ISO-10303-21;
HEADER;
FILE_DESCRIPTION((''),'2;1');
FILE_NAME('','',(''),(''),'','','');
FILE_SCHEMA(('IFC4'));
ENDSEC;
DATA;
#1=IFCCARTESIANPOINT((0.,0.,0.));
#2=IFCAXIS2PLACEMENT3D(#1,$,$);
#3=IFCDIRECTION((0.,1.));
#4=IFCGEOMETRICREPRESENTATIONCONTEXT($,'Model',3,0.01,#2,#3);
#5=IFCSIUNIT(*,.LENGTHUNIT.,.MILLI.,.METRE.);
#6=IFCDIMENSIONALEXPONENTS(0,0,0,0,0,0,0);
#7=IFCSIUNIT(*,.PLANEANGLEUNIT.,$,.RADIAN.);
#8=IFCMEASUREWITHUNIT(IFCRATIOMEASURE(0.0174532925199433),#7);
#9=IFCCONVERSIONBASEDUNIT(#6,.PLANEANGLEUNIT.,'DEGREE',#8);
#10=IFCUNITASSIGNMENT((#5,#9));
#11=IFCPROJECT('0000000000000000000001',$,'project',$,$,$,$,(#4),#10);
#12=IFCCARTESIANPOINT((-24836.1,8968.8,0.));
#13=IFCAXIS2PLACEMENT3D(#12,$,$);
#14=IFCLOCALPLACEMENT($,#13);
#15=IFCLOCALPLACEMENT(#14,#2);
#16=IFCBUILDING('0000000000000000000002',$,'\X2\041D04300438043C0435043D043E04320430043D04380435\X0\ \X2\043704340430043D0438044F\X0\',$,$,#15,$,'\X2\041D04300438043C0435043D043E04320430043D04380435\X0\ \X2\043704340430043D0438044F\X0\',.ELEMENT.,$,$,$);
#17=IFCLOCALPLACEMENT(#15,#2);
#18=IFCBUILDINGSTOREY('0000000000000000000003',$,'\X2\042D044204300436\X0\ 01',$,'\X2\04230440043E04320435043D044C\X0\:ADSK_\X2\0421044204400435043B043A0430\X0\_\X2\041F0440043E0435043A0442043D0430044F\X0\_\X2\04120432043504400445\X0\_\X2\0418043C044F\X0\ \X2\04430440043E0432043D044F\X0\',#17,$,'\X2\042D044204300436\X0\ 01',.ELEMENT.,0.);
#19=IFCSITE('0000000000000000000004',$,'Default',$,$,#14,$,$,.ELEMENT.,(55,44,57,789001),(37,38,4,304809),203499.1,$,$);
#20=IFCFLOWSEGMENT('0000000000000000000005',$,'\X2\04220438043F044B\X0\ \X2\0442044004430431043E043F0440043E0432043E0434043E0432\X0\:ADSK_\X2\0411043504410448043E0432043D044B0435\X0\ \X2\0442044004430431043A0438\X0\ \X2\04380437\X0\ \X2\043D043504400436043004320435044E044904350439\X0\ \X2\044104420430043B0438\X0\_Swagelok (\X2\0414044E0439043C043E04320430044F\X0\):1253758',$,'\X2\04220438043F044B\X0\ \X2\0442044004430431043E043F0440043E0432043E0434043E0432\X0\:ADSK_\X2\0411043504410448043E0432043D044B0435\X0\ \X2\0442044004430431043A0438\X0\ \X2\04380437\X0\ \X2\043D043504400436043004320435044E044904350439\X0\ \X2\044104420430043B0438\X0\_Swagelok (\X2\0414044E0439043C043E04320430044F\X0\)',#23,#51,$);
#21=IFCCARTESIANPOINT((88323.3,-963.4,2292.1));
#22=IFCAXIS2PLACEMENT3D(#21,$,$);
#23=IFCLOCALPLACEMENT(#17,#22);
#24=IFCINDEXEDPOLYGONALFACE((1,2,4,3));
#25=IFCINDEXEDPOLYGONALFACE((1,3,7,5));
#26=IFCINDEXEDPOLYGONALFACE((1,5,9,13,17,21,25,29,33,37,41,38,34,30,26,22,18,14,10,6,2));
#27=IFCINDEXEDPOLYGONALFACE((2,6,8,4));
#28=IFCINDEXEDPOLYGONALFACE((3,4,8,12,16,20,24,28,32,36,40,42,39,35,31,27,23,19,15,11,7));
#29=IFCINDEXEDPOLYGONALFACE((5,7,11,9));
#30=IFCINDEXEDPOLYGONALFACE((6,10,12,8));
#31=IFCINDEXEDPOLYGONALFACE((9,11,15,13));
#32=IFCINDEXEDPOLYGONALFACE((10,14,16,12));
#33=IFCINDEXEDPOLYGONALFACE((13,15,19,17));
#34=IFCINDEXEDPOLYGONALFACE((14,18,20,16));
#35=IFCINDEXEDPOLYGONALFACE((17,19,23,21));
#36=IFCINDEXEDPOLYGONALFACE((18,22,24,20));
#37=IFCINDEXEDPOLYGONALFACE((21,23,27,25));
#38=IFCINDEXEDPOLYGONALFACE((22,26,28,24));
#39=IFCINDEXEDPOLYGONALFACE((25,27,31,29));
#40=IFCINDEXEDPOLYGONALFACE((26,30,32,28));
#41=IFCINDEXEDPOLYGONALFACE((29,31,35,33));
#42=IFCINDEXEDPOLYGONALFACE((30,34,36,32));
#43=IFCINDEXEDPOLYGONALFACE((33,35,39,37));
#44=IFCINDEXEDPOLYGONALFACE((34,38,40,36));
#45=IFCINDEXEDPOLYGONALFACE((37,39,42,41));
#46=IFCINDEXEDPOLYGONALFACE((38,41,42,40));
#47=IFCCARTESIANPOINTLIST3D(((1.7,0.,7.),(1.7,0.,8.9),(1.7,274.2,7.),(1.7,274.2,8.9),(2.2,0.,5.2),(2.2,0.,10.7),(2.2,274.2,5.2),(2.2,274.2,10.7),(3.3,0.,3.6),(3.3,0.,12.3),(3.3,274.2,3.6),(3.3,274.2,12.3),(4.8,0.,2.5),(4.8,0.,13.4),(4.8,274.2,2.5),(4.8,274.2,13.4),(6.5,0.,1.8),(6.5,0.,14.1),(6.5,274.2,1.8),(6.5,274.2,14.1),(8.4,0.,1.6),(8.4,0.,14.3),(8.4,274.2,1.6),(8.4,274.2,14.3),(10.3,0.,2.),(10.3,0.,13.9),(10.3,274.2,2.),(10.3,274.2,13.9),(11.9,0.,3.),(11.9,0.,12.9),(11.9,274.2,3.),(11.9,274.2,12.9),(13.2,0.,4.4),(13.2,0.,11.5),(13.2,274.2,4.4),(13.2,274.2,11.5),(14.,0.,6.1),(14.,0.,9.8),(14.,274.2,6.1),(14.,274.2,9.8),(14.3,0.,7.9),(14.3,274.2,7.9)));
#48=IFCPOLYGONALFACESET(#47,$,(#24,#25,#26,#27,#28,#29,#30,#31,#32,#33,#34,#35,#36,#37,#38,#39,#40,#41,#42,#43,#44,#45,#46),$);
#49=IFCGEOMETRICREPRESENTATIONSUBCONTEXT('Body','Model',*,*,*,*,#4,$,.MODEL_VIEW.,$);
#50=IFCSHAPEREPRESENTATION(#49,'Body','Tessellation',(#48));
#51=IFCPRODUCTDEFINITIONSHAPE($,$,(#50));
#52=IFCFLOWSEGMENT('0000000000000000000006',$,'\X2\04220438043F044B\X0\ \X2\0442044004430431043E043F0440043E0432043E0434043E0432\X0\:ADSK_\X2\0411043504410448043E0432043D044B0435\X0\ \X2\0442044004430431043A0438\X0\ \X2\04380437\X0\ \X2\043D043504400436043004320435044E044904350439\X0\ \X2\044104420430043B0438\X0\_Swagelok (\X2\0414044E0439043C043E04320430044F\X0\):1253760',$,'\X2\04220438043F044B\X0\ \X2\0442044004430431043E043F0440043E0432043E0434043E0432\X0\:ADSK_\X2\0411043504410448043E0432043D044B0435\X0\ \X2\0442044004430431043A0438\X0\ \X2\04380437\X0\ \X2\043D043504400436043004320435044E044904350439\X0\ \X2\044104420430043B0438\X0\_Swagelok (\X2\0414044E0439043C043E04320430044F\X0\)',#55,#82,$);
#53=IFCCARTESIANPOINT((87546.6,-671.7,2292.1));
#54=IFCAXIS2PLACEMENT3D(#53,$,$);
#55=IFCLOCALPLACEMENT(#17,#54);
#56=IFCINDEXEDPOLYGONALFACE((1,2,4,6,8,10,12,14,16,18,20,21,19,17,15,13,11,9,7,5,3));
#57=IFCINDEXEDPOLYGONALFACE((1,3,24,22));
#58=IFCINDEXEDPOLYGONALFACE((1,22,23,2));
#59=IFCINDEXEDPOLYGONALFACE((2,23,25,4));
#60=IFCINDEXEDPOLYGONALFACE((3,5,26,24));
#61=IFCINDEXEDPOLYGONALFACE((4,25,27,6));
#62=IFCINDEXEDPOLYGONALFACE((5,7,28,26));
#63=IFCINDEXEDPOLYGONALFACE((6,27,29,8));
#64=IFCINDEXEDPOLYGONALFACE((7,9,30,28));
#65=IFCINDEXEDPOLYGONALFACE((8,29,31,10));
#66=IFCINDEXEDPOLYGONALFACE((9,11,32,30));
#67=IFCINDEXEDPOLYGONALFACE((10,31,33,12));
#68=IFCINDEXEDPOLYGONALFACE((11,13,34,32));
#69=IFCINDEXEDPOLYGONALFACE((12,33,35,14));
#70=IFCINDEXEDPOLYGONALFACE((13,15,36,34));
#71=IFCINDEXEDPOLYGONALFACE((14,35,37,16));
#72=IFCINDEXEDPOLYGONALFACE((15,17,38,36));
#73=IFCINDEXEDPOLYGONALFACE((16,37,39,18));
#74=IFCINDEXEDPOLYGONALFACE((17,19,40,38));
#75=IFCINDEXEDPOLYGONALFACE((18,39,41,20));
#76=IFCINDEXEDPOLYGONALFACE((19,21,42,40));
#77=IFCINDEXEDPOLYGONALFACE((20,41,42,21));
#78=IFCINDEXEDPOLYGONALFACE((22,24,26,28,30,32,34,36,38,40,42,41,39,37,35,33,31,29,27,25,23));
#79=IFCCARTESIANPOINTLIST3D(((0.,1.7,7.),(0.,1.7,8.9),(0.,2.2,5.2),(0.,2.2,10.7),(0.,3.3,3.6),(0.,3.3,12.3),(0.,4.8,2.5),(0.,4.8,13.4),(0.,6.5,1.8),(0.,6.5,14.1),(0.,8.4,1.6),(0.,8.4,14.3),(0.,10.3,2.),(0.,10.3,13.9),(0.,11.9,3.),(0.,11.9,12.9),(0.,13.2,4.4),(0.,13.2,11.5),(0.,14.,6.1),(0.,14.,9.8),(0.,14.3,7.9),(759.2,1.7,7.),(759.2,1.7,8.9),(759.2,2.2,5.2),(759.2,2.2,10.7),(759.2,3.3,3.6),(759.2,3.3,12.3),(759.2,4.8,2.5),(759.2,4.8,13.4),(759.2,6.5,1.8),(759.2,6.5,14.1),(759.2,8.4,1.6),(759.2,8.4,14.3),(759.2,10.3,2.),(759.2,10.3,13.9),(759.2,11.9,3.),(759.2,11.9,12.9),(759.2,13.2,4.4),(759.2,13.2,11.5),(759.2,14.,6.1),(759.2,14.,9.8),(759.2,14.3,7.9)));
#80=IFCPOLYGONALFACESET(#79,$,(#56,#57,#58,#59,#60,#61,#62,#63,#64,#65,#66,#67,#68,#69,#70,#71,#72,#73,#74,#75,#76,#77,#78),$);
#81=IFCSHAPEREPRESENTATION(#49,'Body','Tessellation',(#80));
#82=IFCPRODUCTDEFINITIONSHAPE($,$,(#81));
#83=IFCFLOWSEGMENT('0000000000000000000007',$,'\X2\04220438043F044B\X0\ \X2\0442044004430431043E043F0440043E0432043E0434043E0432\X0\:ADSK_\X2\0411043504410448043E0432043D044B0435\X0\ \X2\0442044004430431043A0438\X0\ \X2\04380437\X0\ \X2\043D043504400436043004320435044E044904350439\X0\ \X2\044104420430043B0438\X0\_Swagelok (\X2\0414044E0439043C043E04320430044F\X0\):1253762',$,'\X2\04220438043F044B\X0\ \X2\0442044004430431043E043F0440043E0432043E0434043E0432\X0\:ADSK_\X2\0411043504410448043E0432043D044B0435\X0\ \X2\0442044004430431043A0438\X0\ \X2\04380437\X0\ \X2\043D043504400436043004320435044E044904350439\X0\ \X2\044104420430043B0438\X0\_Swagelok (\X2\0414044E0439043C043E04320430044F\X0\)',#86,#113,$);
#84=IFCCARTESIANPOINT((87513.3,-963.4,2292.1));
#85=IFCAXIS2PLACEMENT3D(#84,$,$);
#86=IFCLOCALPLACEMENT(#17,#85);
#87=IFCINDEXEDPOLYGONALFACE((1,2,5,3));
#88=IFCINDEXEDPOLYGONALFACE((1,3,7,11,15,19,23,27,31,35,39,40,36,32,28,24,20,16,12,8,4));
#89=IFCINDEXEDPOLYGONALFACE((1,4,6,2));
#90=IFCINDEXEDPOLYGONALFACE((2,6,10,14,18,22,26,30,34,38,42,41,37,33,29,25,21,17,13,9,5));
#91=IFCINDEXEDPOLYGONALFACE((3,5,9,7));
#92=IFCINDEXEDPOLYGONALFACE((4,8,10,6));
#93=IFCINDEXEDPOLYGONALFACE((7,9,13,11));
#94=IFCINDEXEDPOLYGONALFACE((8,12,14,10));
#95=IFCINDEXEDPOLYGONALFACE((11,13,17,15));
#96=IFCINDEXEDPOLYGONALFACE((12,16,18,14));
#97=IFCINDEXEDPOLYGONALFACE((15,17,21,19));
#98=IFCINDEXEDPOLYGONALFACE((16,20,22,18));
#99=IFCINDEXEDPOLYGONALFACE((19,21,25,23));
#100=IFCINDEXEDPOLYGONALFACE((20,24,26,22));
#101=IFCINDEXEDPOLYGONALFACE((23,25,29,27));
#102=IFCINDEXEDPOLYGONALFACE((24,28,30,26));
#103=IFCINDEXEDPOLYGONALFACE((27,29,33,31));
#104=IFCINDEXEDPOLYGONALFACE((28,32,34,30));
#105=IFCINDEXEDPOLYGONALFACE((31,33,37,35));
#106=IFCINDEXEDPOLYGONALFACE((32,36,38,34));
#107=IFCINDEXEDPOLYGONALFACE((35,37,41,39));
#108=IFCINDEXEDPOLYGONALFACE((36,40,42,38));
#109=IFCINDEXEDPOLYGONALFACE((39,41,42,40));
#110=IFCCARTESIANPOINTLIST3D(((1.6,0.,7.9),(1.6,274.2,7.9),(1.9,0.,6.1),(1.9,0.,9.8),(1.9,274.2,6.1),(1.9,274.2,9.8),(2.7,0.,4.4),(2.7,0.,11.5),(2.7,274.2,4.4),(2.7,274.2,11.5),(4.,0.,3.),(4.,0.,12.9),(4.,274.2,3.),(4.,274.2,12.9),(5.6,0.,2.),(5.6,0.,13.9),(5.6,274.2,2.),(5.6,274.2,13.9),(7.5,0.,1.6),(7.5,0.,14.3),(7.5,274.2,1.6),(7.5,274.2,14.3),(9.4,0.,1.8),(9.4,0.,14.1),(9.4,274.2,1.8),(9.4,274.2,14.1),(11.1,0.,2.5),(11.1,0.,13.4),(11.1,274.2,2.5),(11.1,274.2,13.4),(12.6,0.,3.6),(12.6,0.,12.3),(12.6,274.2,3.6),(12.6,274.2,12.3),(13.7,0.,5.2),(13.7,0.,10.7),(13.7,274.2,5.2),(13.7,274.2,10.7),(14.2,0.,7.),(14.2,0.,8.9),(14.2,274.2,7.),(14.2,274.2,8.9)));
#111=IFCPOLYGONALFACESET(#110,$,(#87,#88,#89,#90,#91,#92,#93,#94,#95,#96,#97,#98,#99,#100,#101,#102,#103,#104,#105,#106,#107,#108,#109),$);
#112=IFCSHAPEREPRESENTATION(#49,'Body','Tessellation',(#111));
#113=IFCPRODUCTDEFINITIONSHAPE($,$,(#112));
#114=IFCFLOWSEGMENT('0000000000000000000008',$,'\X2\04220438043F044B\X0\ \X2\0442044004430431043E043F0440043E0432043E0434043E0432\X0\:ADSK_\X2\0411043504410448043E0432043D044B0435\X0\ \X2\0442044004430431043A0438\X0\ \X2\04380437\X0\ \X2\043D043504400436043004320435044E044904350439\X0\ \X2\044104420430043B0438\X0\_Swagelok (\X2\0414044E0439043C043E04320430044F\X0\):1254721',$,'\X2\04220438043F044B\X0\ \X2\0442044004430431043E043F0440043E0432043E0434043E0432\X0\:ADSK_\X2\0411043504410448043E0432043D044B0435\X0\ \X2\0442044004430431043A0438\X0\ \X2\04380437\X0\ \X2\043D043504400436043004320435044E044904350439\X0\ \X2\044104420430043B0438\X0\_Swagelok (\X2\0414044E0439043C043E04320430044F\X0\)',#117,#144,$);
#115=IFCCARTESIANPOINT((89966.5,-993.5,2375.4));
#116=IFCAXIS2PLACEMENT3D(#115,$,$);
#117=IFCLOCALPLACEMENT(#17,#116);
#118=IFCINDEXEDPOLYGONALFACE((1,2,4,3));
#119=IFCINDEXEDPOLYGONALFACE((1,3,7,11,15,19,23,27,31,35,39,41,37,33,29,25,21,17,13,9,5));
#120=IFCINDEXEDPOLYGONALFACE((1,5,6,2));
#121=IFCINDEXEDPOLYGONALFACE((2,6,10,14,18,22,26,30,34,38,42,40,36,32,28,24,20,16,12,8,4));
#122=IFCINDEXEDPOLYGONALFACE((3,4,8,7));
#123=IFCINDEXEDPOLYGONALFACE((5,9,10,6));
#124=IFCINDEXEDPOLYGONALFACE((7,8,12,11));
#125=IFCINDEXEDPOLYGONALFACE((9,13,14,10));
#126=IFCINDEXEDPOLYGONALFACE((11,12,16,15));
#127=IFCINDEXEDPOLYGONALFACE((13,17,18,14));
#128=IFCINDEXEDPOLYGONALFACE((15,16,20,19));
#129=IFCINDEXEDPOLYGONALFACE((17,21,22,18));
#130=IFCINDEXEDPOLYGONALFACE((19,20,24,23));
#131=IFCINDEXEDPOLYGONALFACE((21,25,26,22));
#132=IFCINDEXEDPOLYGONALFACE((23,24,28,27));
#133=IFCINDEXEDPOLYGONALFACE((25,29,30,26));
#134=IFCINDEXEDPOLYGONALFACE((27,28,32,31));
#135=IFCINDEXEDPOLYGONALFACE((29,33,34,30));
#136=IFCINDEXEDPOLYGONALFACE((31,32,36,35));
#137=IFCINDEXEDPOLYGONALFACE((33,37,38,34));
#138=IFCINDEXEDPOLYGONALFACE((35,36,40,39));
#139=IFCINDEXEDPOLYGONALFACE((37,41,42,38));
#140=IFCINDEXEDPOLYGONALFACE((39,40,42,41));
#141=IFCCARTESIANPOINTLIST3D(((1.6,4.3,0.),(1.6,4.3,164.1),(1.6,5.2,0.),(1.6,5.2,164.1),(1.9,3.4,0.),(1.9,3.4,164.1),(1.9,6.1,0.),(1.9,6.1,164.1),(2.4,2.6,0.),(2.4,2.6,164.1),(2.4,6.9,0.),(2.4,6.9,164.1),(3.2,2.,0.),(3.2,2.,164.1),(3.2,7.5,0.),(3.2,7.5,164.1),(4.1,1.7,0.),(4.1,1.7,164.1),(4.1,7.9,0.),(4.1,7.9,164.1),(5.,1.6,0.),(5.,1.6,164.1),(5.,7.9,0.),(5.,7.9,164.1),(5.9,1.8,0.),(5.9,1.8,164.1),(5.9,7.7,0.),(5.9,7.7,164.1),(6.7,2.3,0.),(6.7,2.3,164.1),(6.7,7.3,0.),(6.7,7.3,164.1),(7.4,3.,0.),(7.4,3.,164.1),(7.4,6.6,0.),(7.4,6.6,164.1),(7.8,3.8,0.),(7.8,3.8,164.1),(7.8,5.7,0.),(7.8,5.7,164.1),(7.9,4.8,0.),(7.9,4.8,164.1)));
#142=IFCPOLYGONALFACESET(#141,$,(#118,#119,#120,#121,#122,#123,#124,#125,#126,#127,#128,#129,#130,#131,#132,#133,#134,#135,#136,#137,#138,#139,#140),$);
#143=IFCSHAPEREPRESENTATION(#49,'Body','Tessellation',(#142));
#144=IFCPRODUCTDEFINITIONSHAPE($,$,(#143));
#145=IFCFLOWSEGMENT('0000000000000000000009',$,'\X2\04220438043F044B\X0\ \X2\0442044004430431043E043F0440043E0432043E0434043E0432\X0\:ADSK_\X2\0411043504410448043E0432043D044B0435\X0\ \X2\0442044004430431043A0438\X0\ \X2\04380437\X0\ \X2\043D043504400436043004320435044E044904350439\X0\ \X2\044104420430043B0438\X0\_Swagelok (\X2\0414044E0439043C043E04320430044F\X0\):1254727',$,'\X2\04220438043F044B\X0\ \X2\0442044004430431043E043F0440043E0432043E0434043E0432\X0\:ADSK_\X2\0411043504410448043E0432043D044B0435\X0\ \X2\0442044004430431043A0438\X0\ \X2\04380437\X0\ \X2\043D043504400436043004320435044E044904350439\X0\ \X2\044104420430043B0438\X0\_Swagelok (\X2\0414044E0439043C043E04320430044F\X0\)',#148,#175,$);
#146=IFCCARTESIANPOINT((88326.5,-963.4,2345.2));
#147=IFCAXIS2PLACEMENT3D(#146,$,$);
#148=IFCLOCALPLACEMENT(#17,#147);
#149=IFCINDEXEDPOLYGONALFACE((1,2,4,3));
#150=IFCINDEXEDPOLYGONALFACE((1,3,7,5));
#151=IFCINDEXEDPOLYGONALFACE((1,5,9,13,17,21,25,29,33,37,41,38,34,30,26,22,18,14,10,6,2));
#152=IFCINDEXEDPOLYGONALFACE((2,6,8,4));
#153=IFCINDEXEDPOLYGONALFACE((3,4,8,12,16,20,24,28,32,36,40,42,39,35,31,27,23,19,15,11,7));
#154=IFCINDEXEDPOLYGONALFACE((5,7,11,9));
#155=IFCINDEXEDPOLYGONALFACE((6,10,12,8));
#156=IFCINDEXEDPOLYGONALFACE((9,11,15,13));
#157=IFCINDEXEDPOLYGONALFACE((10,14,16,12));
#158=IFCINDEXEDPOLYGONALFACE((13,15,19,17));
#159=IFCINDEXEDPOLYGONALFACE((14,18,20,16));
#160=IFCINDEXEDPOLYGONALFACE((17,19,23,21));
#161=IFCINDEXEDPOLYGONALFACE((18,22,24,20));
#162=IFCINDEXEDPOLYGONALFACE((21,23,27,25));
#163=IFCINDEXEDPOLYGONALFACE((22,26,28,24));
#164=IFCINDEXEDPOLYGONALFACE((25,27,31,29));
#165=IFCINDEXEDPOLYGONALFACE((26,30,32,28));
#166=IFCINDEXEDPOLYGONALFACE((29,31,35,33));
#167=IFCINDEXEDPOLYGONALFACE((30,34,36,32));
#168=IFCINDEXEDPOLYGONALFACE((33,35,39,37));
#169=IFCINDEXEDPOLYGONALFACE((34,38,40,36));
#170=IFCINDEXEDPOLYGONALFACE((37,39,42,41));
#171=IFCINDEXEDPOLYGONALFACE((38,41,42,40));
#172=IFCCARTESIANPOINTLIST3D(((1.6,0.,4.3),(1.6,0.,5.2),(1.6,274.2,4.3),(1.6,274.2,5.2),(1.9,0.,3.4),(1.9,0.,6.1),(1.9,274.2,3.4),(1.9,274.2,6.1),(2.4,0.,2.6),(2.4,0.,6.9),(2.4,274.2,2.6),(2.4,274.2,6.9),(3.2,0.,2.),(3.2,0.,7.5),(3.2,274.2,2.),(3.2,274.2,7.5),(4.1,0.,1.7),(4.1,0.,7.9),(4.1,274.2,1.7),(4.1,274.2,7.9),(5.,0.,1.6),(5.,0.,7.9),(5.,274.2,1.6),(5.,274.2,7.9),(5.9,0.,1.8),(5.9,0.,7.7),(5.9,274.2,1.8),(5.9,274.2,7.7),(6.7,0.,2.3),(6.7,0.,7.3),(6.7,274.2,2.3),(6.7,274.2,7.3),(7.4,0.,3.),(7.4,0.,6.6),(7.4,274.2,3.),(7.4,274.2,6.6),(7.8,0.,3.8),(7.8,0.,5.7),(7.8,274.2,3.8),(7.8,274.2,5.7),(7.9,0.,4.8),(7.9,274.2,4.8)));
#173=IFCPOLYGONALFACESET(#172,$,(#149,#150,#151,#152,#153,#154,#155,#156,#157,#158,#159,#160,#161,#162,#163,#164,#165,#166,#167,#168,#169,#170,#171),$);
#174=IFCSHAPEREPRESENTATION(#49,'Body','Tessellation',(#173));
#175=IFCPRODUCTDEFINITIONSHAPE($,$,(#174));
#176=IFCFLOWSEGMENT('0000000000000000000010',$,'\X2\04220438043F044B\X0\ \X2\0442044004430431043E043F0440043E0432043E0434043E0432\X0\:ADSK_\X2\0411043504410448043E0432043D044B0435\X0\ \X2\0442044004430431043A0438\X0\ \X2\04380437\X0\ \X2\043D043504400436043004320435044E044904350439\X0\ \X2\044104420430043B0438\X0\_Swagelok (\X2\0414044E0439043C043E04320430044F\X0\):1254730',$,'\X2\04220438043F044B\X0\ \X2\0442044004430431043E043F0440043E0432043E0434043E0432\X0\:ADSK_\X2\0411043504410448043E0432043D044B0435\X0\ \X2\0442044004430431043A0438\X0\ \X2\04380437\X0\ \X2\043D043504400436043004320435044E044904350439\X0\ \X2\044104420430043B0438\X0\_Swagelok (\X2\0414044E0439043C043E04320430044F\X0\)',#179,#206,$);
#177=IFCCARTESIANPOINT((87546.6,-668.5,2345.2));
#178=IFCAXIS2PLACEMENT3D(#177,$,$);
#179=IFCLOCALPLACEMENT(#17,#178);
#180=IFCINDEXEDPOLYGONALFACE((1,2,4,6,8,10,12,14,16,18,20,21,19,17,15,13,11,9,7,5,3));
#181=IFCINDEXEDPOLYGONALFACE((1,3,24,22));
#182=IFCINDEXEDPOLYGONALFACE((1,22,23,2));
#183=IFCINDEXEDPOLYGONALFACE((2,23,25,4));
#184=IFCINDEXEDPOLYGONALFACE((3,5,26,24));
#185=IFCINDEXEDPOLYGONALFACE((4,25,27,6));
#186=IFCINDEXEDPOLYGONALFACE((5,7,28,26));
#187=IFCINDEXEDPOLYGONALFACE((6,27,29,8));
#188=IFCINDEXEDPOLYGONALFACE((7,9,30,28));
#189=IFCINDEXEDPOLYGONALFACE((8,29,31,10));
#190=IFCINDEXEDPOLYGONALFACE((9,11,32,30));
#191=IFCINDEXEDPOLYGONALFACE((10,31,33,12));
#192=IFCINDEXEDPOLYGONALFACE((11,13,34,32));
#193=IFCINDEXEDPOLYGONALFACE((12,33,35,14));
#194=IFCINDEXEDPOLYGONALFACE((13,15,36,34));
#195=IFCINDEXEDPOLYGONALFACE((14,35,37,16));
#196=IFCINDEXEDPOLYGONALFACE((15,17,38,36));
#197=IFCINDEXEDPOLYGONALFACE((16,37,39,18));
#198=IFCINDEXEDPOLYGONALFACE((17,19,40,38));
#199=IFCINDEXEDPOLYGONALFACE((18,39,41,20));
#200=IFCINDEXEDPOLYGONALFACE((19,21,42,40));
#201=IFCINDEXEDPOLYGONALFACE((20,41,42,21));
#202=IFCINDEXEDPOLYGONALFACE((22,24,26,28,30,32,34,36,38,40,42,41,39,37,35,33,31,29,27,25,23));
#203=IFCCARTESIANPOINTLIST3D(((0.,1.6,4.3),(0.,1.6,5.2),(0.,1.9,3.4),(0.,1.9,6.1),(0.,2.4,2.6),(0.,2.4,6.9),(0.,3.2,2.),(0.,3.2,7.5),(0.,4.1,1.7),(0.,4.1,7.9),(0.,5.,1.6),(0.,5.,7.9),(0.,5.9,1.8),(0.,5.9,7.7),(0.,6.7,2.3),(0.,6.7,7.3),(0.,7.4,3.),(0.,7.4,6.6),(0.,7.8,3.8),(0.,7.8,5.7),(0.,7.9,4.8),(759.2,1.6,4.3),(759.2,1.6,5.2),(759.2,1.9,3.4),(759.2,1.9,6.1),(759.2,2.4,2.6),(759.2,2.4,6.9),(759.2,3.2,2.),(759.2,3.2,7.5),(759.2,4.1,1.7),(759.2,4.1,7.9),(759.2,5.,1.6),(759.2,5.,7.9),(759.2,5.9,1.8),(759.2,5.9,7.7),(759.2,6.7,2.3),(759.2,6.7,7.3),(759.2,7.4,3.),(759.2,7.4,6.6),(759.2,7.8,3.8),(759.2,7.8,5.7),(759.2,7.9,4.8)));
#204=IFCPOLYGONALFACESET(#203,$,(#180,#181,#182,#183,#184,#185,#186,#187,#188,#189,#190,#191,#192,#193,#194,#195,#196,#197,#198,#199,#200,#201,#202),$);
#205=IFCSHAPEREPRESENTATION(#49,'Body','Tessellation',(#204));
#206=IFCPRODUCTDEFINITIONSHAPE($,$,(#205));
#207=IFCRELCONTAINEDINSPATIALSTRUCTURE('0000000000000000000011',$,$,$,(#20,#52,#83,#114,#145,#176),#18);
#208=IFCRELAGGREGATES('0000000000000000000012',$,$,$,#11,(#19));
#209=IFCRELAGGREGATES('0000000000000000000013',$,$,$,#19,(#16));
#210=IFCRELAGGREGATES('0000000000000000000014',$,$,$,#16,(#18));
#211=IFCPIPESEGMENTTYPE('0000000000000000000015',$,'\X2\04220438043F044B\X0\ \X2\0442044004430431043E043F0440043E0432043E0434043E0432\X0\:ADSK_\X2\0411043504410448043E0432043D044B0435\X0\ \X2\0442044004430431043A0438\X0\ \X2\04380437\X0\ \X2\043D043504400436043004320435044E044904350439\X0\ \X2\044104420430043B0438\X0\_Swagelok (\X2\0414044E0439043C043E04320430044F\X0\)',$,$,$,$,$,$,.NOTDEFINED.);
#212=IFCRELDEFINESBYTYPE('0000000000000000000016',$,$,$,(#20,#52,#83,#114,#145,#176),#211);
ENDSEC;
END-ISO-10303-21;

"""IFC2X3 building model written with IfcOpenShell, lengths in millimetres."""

from ifc_helpers import new_model, entity, si_unit, converted_unit, direction, frame, origin, origin_2d_with_axis, place, context, subcontext, project, spatial, circle, extrude, type_object, element, save


model = new_model("IFC2X3")

# Units and contexts
model_context = context("Model", 3, precision=0.01, world=origin(), true_north=direction((0.0, 1.0)))
body_context = subcontext(model_context, "Body", "Model", "MODEL_VIEW")
ifc_project = project(units=[si_unit("LENGTHUNIT", "METRE", prefix="MILLI"), converted_unit("PLANEANGLEUNIT", "DEGREE", entity("IfcRatioMeasure", 0.0174532925199433), si_unit("PLANEANGLEUNIT", "RADIAN"), dimensions=[0, 0, 0, 0, 0, 0, 0])], contexts=[model_context])

# Site, building, storey
site_placement = place(None, frame((-24836.1, 8968.8, 0.0)))
site = spatial("IfcSite", under=ifc_project, at=site_placement, Name="Default", CompositionType="ELEMENT", RefLatitude=(55, 44, 57, 789001), RefLongitude=(37, 38, 4, 304809), RefElevation=203499.1)
building_placement = place(site_placement, origin())
building = spatial("IfcBuilding", under=site, at=building_placement, Name="Наименование здания", LongName="Наименование здания", CompositionType="ELEMENT")
storey_placement = place(building_placement, origin())
storey = spatial("IfcBuildingStorey", under=building, at=storey_placement, Name="Этаж 01", ObjectType="Уровень:ADSK_Стрелка_Проектная_Вверх_Имя уровня", LongName="Этаж 01", CompositionType="ELEMENT", Elevation=0.0)

# Flow segments
pipe_segment_type_1 = type_object("IfcPipeSegmentType", Name="Типы трубопроводов:ADSK_Бесшовные трубки из нержавеющей стали_Swagelok (Дюймовая)", PredefinedType="NOTDEFINED")
flow_segment_1_placement = place(storey_placement, frame((88323.3, -963.4, 2292.1)))
element("IfcFlowSegment", 1, at=flow_segment_1_placement, inside=storey, type_object=pipe_segment_type_1, Name="Типы трубопроводов:ADSK_Бесшовные трубки из нержавеющей стали_Swagelok (Дюймовая):1253758", ObjectType="Типы трубопроводов:ADSK_Бесшовные трубки из нержавеющей стали_Swagelok (Дюймовая)", context=body_context, shape_type="SweptSolid", body=[
    extrude(circle(Radius=6.3, at=origin_2d_with_axis()), frame((8.0, 0.0, 8.0), z_axis=(0.0, 1.0, 0.0), x_axis=(1.0, 0.0, 0.0)), (0.0, 0.0, 1.0), 274.2),
])
flow_segment_2_placement = place(storey_placement, frame((87546.6, -671.7, 2292.1)))
element("IfcFlowSegment", 2, at=flow_segment_2_placement, inside=storey, type_object=pipe_segment_type_1, Name="Типы трубопроводов:ADSK_Бесшовные трубки из нержавеющей стали_Swagelok (Дюймовая):1253760", ObjectType="Типы трубопроводов:ADSK_Бесшовные трубки из нержавеющей стали_Swagelok (Дюймовая)", context=body_context, shape_type="SweptSolid", body=[
    extrude(circle(Radius=6.3, at=origin_2d_with_axis()), frame((0.0, 8.0, 8.0), z_axis=(1.0, 0.0, 0.0), x_axis=(0.0, 1.0, 0.0)), (0.0, 0.0, 1.0), 759.2),
])
flow_segment_3_placement = place(storey_placement, frame((87513.3, -963.4, 2292.1)))
element("IfcFlowSegment", 3, at=flow_segment_3_placement, inside=storey, type_object=pipe_segment_type_1, Name="Типы трубопроводов:ADSK_Бесшовные трубки из нержавеющей стали_Swagelok (Дюймовая):1253762", ObjectType="Типы трубопроводов:ADSK_Бесшовные трубки из нержавеющей стали_Swagelok (Дюймовая)", context=body_context, shape_type="SweptSolid", body=[
    extrude(circle(Radius=6.3, at=origin_2d_with_axis()), frame((8.0, 0.0, 8.0), z_axis=(0.0, 1.0, 0.0), x_axis=(-1.0, 0.0, 0.0)), (0.0, 0.0, 1.0), 274.2),
])
flow_segment_4_placement = place(storey_placement, frame((89966.5, -993.5, 2375.4)))
element("IfcFlowSegment", 4, at=flow_segment_4_placement, inside=storey, type_object=pipe_segment_type_1, Name="Типы трубопроводов:ADSK_Бесшовные трубки из нержавеющей стали_Swagelok (Дюймовая):1254721", ObjectType="Типы трубопроводов:ADSK_Бесшовные трубки из нержавеющей стали_Swagelok (Дюймовая)", context=body_context, shape_type="SweptSolid", body=[
    extrude(circle(Radius=3.2, at=origin_2d_with_axis()), frame((4.8, 4.8, 0.0)), (0.0, 0.0, 1.0), 164.1),
])
flow_segment_5_placement = place(storey_placement, frame((88326.5, -963.4, 2345.2)))
element("IfcFlowSegment", 5, at=flow_segment_5_placement, inside=storey, type_object=pipe_segment_type_1, Name="Типы трубопроводов:ADSK_Бесшовные трубки из нержавеющей стали_Swagelok (Дюймовая):1254727", ObjectType="Типы трубопроводов:ADSK_Бесшовные трубки из нержавеющей стали_Swagelok (Дюймовая)", context=body_context, shape_type="SweptSolid", body=[
    extrude(circle(Radius=3.2, at=origin_2d_with_axis()), frame((4.8, 0.0, 4.8), z_axis=(0.0, 1.0, 0.0), x_axis=(1.0, 0.0, 0.0)), (0.0, 0.0, 1.0), 274.2),
])
flow_segment_6_placement = place(storey_placement, frame((87546.6, -668.5, 2345.2)))
element("IfcFlowSegment", 6, at=flow_segment_6_placement, inside=storey, type_object=pipe_segment_type_1, Name="Типы трубопроводов:ADSK_Бесшовные трубки из нержавеющей стали_Swagelok (Дюймовая):1254730", ObjectType="Типы трубопроводов:ADSK_Бесшовные трубки из нержавеющей стали_Swagelok (Дюймовая)", context=body_context, shape_type="SweptSolid", body=[
    extrude(circle(Radius=3.2, at=origin_2d_with_axis()), frame((0.0, 4.8, 4.8), z_axis=(1.0, 0.0, 0.0), x_axis=(0.0, 1.0, 0.0)), (0.0, 0.0, 1.0), 759.2),
])

save(model, "model.ifc")
